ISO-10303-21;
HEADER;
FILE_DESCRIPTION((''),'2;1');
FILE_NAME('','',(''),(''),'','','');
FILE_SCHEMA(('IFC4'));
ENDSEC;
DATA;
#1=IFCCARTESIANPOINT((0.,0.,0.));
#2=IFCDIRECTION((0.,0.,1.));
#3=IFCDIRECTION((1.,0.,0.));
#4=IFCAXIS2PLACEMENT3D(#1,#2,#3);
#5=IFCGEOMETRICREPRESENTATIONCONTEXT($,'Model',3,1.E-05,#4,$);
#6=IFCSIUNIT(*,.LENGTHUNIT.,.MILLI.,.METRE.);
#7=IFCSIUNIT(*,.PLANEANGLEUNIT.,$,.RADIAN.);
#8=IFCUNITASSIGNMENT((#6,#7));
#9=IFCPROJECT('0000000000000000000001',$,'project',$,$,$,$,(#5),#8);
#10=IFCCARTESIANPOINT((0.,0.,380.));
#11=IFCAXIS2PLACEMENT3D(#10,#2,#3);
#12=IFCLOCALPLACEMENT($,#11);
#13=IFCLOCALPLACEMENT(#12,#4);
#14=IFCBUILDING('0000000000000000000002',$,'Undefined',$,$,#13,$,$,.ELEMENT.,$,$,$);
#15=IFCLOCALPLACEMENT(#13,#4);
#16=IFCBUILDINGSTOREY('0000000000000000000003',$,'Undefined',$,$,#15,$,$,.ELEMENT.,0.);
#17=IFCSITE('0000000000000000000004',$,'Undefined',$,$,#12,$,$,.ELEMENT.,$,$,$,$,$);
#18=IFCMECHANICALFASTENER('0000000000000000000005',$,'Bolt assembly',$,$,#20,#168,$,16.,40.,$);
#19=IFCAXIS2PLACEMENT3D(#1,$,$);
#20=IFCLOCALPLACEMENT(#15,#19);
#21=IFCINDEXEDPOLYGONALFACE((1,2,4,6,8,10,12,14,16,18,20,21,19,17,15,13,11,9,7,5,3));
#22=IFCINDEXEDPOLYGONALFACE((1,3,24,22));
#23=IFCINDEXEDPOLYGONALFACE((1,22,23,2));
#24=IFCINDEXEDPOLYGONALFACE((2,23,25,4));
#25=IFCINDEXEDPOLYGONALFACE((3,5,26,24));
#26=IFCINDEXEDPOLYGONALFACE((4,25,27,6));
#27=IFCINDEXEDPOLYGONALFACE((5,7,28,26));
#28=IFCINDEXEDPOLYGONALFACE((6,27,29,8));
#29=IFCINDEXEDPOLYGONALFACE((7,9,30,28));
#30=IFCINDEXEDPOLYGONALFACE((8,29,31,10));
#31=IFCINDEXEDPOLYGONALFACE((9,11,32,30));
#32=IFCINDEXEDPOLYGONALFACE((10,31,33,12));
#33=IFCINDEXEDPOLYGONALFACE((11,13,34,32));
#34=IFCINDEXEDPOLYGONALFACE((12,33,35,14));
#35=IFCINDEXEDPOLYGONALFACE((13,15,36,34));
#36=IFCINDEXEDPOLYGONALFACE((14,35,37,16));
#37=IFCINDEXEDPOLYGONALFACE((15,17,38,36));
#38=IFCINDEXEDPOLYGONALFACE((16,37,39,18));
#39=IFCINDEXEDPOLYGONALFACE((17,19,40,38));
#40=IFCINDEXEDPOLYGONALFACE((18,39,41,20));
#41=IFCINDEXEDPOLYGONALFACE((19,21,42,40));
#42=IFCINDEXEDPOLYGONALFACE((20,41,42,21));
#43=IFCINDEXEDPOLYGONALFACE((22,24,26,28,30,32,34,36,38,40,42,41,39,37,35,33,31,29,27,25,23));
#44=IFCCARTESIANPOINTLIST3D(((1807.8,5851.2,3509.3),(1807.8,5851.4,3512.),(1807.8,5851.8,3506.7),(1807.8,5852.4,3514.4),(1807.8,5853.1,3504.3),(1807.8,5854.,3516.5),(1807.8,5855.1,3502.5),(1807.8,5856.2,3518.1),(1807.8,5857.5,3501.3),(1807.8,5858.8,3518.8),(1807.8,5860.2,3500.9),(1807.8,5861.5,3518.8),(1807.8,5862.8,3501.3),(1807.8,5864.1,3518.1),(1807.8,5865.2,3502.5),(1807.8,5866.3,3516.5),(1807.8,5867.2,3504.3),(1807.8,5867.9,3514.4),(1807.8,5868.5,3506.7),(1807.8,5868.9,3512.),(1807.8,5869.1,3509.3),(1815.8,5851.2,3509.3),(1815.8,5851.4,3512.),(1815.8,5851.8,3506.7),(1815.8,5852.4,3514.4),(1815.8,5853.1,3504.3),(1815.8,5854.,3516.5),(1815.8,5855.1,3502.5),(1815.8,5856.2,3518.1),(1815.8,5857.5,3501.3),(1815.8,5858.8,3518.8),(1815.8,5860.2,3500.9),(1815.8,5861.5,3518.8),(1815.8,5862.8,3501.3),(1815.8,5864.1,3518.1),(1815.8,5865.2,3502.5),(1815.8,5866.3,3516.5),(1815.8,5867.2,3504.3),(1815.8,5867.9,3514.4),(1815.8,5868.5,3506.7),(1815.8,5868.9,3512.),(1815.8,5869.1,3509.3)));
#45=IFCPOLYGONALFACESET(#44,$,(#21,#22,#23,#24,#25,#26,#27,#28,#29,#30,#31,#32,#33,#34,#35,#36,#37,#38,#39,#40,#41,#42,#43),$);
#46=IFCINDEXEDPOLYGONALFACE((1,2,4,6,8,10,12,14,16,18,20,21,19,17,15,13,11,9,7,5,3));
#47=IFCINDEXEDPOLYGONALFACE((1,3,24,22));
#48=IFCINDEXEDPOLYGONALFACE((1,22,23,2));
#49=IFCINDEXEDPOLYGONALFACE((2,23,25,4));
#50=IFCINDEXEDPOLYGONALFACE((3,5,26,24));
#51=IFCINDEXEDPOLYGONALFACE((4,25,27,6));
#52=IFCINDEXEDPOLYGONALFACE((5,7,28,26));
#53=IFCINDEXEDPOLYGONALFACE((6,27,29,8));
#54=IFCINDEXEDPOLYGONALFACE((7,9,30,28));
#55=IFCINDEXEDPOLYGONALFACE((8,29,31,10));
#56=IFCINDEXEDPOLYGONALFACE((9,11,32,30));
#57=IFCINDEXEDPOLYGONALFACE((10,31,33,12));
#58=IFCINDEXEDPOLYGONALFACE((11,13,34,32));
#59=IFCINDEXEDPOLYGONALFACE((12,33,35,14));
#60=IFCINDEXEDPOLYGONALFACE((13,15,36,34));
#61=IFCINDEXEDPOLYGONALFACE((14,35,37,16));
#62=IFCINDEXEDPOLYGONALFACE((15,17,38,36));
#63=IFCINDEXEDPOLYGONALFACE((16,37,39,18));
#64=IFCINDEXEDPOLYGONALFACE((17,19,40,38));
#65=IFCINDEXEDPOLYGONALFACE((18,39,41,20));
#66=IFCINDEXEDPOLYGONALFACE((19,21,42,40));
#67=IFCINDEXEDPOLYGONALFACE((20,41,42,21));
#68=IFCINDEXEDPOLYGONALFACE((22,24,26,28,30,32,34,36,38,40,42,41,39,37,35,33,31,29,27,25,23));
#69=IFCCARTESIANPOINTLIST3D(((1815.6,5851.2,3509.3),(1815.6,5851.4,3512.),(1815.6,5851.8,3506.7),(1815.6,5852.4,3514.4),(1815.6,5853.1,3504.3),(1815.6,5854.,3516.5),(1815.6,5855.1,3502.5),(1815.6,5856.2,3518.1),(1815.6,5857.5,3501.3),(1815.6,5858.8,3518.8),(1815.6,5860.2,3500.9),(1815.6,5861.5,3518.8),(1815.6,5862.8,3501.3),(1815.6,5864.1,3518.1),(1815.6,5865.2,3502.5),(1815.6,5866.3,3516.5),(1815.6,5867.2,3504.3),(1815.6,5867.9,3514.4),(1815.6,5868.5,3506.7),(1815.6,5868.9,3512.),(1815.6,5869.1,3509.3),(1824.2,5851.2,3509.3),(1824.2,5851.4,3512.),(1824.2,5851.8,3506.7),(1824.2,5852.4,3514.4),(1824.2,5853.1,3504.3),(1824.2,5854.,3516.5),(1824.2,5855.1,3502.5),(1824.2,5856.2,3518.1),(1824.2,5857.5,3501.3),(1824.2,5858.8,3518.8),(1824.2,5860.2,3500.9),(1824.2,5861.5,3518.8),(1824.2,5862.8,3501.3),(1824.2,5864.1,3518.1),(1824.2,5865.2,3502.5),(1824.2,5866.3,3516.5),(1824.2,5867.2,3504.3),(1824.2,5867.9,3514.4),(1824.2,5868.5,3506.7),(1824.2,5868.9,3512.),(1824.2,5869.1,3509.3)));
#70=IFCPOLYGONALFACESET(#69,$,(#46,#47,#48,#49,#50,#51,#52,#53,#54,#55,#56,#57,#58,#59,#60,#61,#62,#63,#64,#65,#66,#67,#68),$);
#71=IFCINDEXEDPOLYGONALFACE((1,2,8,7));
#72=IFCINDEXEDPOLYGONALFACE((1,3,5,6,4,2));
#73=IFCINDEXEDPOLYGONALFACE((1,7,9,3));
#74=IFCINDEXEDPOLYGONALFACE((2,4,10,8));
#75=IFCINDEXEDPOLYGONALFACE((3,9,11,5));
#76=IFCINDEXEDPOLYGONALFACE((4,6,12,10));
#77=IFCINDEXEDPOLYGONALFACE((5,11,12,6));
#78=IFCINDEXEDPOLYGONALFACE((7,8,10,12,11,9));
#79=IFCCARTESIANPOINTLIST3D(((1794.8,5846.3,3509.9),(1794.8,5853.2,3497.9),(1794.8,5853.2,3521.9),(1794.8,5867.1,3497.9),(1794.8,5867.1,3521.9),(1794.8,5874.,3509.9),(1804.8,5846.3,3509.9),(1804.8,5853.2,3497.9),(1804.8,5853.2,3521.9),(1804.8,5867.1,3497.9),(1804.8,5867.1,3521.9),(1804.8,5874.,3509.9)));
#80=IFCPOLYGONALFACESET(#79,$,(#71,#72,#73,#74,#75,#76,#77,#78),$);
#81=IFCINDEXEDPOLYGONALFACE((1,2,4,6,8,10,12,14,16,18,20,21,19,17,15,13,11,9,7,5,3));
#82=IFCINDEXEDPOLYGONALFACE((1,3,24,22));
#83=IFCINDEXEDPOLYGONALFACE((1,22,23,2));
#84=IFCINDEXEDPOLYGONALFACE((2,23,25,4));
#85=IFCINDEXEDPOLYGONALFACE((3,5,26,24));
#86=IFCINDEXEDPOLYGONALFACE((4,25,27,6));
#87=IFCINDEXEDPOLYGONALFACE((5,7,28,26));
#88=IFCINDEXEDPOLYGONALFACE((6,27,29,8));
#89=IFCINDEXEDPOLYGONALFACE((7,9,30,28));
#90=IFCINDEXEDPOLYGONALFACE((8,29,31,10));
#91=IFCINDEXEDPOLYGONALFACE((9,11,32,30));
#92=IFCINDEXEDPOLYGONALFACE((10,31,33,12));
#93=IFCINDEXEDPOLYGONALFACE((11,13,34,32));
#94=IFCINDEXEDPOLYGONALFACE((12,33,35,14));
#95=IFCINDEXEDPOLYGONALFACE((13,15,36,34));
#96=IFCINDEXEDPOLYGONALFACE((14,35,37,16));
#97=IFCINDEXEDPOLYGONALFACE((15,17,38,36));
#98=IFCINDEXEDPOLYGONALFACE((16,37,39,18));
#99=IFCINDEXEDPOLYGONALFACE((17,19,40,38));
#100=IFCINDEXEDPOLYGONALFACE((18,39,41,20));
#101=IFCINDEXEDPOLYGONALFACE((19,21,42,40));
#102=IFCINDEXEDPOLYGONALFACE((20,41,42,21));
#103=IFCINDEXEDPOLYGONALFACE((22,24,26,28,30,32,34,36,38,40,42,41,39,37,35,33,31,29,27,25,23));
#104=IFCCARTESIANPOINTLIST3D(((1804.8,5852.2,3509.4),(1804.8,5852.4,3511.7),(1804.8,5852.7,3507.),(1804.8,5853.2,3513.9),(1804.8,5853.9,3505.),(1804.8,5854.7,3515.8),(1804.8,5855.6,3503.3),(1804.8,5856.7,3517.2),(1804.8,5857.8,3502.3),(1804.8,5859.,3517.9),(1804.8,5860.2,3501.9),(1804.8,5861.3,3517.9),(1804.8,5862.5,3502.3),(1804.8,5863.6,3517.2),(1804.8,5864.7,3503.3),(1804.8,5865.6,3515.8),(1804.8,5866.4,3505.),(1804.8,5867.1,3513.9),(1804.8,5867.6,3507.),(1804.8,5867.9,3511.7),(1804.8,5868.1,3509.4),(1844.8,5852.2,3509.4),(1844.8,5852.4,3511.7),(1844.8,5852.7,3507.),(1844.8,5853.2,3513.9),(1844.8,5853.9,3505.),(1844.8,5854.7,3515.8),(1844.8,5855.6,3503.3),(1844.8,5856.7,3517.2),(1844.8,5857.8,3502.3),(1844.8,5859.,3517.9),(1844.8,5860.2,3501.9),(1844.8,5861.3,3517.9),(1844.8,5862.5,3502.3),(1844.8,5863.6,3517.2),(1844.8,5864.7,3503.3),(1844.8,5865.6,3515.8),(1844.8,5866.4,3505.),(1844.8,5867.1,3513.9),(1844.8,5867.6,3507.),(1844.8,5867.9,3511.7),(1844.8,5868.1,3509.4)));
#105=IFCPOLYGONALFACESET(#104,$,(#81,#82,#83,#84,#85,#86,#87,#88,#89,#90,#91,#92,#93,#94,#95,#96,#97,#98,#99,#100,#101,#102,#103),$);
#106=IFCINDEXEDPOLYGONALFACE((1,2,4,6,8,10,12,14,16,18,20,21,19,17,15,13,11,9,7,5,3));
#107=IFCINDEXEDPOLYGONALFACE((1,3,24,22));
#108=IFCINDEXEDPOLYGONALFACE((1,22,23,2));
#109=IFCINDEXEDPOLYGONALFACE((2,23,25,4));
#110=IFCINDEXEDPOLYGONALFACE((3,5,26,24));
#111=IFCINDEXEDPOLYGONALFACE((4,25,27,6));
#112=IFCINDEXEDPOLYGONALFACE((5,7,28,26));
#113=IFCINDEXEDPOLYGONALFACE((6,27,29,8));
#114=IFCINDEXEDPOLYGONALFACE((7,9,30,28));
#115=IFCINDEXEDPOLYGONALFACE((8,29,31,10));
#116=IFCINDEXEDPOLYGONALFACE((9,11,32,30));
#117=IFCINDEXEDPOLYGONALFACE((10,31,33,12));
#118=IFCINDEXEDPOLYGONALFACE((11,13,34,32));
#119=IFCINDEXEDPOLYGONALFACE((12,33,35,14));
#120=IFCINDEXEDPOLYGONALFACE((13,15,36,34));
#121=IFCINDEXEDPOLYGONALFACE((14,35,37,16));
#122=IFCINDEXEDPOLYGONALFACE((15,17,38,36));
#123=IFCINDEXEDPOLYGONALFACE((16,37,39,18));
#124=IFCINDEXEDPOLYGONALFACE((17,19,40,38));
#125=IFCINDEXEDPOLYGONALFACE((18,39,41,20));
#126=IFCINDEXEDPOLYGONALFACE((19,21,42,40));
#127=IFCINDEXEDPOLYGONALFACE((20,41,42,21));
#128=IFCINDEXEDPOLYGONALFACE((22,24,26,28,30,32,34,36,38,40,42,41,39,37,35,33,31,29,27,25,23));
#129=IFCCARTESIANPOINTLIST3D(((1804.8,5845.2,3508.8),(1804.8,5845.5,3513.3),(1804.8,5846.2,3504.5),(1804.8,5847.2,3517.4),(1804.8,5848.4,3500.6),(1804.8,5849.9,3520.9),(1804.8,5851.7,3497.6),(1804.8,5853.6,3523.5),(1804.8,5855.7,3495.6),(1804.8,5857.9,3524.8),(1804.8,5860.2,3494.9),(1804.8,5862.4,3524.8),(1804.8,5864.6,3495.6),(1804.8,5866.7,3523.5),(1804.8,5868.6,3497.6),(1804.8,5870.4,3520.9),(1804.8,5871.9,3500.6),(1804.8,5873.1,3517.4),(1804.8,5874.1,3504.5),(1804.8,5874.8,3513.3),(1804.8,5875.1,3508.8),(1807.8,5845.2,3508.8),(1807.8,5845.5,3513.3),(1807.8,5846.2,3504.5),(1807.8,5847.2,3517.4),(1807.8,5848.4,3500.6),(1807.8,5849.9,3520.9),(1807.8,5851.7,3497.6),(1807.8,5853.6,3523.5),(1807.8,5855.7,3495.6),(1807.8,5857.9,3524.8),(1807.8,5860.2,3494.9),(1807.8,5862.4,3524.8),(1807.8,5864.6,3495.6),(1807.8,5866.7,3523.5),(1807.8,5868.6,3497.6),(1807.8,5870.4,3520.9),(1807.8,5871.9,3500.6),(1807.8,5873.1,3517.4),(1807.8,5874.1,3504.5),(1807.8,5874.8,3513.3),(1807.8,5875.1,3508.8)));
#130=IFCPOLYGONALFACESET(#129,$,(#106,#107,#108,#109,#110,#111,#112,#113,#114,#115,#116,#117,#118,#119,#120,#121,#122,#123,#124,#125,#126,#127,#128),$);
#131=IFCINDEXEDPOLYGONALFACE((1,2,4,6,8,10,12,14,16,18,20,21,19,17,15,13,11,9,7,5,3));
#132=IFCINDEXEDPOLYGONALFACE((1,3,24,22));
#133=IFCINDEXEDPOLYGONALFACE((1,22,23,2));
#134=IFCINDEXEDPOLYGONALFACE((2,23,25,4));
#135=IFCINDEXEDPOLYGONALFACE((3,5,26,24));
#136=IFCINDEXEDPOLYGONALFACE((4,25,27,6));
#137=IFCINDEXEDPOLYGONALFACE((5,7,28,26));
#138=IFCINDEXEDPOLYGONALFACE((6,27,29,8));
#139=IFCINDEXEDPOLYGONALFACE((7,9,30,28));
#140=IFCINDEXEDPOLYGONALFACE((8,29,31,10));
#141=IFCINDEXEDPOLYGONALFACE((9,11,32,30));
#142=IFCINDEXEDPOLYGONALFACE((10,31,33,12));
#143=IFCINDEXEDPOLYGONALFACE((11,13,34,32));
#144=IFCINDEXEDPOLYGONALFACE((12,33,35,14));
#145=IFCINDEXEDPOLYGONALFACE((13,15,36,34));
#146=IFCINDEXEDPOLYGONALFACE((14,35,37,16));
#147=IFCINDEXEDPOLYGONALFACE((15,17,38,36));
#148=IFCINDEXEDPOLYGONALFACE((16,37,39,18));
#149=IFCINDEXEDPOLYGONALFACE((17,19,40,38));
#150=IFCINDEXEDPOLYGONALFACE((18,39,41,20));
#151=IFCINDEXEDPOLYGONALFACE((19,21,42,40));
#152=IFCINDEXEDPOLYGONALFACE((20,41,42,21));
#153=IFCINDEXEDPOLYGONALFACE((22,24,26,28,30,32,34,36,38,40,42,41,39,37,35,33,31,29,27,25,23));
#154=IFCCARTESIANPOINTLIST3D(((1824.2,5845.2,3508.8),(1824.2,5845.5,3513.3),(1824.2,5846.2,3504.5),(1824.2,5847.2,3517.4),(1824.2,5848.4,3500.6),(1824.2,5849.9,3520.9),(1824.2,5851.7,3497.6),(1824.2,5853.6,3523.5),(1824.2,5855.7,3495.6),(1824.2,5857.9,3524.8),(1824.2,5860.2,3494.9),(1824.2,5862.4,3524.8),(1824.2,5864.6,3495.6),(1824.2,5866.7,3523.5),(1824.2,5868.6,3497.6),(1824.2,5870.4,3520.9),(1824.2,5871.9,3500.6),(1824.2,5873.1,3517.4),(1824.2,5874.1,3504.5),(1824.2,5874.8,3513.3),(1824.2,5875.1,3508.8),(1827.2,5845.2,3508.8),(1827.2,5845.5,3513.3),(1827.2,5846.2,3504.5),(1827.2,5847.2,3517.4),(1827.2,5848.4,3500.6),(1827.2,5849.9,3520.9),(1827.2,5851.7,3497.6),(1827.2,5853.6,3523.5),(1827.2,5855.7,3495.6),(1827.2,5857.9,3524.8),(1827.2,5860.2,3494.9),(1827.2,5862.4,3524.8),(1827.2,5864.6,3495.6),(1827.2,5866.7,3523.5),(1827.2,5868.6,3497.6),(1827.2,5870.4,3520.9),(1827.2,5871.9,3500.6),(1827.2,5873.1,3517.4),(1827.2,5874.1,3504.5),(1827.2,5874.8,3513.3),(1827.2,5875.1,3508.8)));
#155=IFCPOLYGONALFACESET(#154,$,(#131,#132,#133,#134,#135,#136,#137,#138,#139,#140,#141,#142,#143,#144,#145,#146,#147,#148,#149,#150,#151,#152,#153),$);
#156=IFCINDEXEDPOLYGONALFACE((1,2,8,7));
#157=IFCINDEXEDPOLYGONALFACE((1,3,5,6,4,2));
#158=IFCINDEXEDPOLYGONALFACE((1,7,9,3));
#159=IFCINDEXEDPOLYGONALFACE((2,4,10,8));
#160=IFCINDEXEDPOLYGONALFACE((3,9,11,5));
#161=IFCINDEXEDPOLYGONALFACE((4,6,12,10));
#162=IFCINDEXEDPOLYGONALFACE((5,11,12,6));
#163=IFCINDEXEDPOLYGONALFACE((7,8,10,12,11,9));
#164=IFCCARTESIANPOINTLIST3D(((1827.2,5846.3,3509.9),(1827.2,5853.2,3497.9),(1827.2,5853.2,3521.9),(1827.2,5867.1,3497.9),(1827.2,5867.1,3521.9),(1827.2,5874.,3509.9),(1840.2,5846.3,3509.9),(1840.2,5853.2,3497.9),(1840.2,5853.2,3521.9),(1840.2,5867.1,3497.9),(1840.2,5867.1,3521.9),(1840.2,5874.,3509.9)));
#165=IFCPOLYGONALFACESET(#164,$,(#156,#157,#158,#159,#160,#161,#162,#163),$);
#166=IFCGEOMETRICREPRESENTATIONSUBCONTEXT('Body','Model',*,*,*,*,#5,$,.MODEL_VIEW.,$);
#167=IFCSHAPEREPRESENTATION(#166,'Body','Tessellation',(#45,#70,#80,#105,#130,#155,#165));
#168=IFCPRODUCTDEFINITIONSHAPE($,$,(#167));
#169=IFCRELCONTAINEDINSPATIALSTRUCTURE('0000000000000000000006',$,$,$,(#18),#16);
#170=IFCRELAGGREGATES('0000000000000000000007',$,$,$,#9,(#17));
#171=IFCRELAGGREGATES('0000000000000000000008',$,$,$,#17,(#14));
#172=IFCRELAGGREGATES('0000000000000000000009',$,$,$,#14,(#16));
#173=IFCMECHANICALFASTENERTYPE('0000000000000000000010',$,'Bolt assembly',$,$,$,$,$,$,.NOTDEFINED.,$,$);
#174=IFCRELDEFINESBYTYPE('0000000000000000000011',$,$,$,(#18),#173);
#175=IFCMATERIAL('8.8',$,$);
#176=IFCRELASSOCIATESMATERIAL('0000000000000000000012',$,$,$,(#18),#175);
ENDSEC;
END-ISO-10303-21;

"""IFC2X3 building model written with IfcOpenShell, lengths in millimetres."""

from ifc_helpers import new_model, si_unit, frame, origin_with_axes, origin_2d_with_axis, place, context, subcontext, project, spatial, polyline, circle, outline, extrude, source, transform, mapped, material, type_object, element, save


model = new_model("IFC2X3")

# Units and contexts
model_context = context("Model", 3, precision=1e-05, world=origin_with_axes())
body_context = subcontext(model_context, "Body", "Model", "MODEL_VIEW")
ifc_project = project(units=[si_unit("LENGTHUNIT", "METRE", prefix="MILLI"), si_unit("PLANEANGLEUNIT", "RADIAN")], contexts=[model_context])

# Site, building, storey
site_placement = place(None, frame((0.0, 0.0, 380.0), z_axis=(0.0, 0.0, 1.0), x_axis=(1.0, 0.0, 0.0)))
site = spatial("IfcSite", under=ifc_project, at=site_placement, Name="Undefined", CompositionType="ELEMENT")
building_placement = place(site_placement, origin_with_axes())
building = spatial("IfcBuilding", under=site, at=building_placement, Name="Undefined", CompositionType="ELEMENT")
storey_placement = place(building_placement, origin_with_axes())
storey = spatial("IfcBuildingStorey", under=building, at=storey_placement, Name="Undefined", CompositionType="ELEMENT", Elevation=0.0)

# Mechanical fastener
ifc_material_1 = material(Name="8.8")
mechanical_fastener_type = type_object("IfcMechanicalFastenerType", Name="Bolt assembly")
shared_shape_1 = source(origin_with_axes(), body_context, "Body", "SweptSolid", [
    extrude(circle(Radius=9.0, at=origin_2d_with_axis()), frame((0.0, -7.9, 0.0), z_axis=(0.0, 1.0, 0.0), x_axis=(1.0, 0.0, 0.0)), (0.0, 0.0, 1.0), 8.0),
    extrude(circle(Radius=9.0, at=origin_2d_with_axis()), frame((0.0, -0.1, 0.0), z_axis=(0.0, 1.0, 0.0), x_axis=(1.0, 0.0, 0.0)), (0.0, 0.0, 1.0), 8.6),
    extrude(outline(polyline([(12.0, -6.9), (12.0, 6.9), (0.0, 13.9), (-12.0, 6.9), (-12.0, -6.9), (0.0, -13.9), (12.0, -6.9)])), frame((0.0, -21.0, 0.0), z_axis=(0.0, 1.0, 0.0), x_axis=(1.0, 0.0, 0.0)), (0.0, 0.0, 1.0), 10.0),
    extrude(circle(Radius=8.0, at=origin_2d_with_axis()), frame((0.0, -11.0, 0.0), z_axis=(0.0, 1.0, 0.0), x_axis=(1.0, 0.0, 0.0)), (0.0, 0.0, 1.0), 40.0),
    extrude(circle(Radius=15.0, at=origin_2d_with_axis()), frame((0.0, -11.0, 0.0), z_axis=(0.0, 1.0, 0.0), x_axis=(1.0, 0.0, 0.0)), (0.0, 0.0, 1.0), 3.0),
    extrude(circle(Radius=15.0, at=origin_2d_with_axis()), frame((0.0, 8.5, 0.0), z_axis=(0.0, 1.0, 0.0), x_axis=(1.0, 0.0, 0.0)), (0.0, 0.0, 1.0), 3.0),
    extrude(outline(polyline([(12.0, -6.9), (12.0, 6.9), (0.0, 13.9), (-12.0, 6.9), (-12.0, -6.9), (0.0, -13.9), (12.0, -6.9)])), frame((0.0, 11.5, 0.0), z_axis=(0.0, 1.0, 0.0), x_axis=(1.0, 0.0, 0.0)), (0.0, 0.0, 1.0), 13.0),
])
mechanical_fastener_1_placement = place(storey_placement, frame((1815.8, 5897.7, 3579.9), z_axis=(0.0, -1.0, 0.0), x_axis=(0.0, 0.0, -1.0)))
element("IfcMechanicalFastener", 1, at=mechanical_fastener_1_placement, inside=storey, type_object=mechanical_fastener_type, material=ifc_material_1, Name="Bolt assembly", NominalDiameter=16.0, NominalLength=40.0, context=body_context, shape_type="MappedRepresentation", body=[
    mapped(shared_shape_1, transform((70.0, 0.0, 37.5))),
])

save(model, "model.ifc")
